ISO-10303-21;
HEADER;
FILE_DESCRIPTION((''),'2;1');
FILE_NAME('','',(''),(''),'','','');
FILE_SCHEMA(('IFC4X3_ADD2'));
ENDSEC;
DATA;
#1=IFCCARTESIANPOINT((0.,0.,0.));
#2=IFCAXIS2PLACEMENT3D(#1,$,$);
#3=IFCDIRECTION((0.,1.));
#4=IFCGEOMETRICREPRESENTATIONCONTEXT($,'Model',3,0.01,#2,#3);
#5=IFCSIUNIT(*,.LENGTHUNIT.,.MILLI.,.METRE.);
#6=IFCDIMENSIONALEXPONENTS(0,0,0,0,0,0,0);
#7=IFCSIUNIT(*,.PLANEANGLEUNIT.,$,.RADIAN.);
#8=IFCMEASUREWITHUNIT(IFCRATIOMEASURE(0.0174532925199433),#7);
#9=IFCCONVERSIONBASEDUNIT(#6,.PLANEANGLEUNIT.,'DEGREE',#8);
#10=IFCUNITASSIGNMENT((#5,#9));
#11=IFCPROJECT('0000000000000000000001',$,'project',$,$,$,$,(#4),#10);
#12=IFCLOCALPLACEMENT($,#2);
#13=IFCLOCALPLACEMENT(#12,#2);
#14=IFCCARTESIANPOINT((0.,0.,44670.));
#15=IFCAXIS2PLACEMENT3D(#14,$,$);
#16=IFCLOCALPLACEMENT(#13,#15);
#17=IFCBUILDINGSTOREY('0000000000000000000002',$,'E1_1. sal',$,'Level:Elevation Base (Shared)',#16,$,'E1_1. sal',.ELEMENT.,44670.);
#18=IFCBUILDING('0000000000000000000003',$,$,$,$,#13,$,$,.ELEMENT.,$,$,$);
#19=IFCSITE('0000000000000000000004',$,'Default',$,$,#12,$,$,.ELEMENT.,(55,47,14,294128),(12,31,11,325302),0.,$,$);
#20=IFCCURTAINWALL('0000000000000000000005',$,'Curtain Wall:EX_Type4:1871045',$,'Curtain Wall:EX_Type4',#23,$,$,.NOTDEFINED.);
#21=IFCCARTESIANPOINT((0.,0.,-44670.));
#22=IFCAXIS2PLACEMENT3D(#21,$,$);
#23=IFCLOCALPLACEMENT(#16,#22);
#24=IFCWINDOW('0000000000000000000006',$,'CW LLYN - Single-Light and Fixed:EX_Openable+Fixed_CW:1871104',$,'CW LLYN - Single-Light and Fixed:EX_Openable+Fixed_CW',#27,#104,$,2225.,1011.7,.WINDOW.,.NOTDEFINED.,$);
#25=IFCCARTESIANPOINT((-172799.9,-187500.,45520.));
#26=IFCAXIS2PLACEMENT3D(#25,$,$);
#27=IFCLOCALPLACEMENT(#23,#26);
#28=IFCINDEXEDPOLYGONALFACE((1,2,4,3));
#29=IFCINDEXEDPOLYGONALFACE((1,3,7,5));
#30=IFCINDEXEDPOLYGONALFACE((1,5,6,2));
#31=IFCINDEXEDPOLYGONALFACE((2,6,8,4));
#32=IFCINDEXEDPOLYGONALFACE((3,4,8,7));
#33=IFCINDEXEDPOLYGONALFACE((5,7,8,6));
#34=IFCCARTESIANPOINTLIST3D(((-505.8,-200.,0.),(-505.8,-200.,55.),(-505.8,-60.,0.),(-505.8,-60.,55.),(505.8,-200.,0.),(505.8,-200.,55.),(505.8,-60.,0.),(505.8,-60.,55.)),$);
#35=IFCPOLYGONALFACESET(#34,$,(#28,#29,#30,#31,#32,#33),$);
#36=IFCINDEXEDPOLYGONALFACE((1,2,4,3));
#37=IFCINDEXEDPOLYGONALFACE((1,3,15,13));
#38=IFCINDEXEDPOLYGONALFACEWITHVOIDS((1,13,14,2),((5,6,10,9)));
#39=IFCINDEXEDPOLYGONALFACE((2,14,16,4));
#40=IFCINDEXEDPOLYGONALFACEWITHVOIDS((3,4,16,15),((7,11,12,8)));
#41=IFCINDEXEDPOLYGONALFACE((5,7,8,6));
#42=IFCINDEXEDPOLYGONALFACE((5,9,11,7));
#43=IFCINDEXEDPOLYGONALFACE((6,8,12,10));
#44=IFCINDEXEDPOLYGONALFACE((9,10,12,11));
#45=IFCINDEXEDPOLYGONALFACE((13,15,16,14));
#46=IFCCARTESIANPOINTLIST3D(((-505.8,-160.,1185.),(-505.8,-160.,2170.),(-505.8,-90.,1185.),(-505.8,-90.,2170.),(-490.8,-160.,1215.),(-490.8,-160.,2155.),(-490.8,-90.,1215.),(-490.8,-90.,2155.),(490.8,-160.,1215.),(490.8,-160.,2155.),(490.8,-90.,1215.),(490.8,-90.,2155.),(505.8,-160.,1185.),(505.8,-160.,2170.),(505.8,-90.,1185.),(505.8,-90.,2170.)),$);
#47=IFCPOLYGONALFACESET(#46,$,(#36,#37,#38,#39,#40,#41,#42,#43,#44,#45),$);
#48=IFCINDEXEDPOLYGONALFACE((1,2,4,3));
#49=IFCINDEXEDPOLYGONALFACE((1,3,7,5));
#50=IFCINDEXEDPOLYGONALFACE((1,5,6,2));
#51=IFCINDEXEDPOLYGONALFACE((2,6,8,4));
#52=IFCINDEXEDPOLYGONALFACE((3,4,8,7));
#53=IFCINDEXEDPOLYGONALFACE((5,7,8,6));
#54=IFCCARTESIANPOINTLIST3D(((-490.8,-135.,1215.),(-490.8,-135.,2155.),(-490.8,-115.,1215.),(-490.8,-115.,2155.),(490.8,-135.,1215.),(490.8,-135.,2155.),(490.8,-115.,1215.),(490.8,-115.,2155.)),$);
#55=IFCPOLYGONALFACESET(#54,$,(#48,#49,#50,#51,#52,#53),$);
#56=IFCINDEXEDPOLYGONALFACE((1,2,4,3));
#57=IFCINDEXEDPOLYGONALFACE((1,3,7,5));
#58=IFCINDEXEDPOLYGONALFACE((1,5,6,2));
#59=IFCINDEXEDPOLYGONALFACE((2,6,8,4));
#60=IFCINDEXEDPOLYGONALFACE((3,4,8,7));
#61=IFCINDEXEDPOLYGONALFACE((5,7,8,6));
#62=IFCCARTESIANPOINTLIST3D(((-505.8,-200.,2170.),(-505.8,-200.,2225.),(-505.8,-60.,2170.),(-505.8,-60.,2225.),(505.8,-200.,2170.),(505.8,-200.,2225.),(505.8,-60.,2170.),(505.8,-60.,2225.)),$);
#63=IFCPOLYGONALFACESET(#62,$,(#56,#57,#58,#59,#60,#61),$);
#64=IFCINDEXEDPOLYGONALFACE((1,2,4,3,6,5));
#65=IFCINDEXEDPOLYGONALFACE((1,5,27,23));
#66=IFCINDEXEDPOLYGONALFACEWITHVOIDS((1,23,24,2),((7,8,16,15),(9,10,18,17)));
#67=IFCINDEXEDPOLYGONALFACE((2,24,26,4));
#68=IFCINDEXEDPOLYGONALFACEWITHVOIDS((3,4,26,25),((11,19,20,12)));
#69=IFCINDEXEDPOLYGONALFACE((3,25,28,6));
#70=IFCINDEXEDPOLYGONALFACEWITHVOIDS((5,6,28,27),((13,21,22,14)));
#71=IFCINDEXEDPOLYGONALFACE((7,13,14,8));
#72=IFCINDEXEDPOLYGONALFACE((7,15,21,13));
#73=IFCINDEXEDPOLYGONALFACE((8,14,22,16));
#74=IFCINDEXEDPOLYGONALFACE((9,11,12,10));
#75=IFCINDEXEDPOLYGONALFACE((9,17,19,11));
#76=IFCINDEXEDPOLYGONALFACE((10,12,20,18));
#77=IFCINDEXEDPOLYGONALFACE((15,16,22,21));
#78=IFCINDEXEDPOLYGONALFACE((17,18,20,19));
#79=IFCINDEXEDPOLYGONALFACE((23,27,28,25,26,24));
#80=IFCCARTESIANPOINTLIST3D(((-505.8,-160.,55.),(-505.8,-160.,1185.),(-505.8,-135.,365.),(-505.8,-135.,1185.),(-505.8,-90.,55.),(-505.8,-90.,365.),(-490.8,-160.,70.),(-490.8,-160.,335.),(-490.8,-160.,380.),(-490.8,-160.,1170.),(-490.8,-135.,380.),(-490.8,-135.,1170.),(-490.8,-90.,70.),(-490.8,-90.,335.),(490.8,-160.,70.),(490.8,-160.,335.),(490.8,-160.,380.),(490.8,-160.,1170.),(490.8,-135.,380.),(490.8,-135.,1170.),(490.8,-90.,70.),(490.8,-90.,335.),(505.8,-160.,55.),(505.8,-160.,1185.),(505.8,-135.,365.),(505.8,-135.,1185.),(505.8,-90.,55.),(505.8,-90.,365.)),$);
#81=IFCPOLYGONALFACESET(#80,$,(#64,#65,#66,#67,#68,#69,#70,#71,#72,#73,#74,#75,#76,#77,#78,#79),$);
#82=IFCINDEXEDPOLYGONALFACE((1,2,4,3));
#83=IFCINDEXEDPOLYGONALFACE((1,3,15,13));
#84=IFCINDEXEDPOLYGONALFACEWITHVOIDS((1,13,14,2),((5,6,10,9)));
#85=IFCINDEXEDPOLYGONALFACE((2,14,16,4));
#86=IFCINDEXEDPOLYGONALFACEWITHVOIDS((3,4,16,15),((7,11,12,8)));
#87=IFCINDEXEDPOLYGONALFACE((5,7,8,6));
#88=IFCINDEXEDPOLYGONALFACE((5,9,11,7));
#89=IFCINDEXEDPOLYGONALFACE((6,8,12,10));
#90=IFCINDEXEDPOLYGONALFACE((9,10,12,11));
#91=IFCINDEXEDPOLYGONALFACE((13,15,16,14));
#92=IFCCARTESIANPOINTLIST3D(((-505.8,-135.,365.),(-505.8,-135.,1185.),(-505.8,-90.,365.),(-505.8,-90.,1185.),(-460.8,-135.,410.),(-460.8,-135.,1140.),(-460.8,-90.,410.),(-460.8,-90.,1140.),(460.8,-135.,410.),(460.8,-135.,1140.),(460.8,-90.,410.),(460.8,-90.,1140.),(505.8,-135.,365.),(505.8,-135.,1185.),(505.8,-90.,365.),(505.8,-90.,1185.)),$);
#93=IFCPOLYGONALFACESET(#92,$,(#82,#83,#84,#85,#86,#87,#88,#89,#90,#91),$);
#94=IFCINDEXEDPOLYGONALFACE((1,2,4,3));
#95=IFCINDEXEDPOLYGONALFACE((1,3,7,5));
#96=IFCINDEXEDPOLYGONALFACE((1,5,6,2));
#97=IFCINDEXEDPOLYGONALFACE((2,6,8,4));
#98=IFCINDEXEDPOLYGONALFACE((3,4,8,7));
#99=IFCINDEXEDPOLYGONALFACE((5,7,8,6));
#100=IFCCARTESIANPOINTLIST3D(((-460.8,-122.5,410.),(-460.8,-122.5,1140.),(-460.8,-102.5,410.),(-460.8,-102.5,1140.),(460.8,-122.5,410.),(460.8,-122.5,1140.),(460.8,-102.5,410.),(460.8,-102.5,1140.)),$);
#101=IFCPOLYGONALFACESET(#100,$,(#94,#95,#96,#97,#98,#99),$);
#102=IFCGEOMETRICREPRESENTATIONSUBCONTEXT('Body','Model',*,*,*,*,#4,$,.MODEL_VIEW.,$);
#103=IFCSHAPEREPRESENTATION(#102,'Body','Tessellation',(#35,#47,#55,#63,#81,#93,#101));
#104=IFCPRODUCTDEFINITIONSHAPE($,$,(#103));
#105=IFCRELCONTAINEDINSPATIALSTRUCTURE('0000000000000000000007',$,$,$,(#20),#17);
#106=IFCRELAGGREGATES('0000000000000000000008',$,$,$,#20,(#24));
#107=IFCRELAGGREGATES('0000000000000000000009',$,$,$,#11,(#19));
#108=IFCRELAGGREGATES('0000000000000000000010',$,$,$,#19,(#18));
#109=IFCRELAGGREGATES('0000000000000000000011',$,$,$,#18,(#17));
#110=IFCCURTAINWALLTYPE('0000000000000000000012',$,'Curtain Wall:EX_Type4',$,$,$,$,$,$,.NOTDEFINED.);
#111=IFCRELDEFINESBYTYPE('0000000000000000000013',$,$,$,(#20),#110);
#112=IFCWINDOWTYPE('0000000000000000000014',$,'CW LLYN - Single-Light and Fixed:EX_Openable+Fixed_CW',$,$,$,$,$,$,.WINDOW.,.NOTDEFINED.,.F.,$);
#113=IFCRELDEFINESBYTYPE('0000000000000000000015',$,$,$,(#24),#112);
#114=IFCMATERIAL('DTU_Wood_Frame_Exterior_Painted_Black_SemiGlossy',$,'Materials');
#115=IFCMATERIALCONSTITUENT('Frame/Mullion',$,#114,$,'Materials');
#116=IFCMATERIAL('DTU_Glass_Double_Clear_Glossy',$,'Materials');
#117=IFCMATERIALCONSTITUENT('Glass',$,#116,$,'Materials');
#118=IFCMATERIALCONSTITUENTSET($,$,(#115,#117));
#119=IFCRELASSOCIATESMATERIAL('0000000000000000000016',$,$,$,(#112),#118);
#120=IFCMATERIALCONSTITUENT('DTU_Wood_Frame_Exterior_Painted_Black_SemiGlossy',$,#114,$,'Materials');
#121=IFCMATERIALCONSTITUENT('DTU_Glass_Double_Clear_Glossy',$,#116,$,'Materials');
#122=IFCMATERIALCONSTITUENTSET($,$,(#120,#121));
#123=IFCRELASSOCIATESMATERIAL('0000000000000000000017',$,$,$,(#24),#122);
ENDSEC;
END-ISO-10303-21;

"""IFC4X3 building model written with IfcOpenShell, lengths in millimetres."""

from ifc_helpers import new_model, entity, si_unit, converted_unit, direction, frame, frame_2d, origin, origin_2d_with_axis, place, context, subcontext, project, spatial, polyline, rectangle, outline, extrude, source, transform, mapped, material, constituent, constituent_set, type_object, type_shapes, element, aggregate, save


model = new_model("IFC4X3")

# Units and contexts
model_context = context("Model", 3, precision=0.01, world=origin(), true_north=direction((0.0, 1.0)))
body_context = subcontext(model_context, "Body", "Model", "MODEL_VIEW")
ifc_project = project(units=[si_unit("LENGTHUNIT", "METRE", prefix="MILLI"), converted_unit("PLANEANGLEUNIT", "DEGREE", entity("IfcRatioMeasure", 0.0174532925199433), si_unit("PLANEANGLEUNIT", "RADIAN"), dimensions=[0, 0, 0, 0, 0, 0, 0])], contexts=[model_context])

# Site, building, storey
site_placement = place(None, origin())
site = spatial("IfcSite", under=ifc_project, at=site_placement, Name="Default", CompositionType="ELEMENT", RefLatitude=(55, 47, 14, 294128), RefLongitude=(12, 31, 11, 325302), RefElevation=0.0)
building_placement = place(site_placement, origin())
building = spatial("IfcBuilding", under=site, at=building_placement, CompositionType="ELEMENT")
storey_placement = place(building_placement, frame((0.0, 0.0, 44670.0)))
storey = spatial("IfcBuildingStorey", under=building, at=storey_placement, Name="E1_1. sal", ObjectType="Level:Elevation Base (Shared)", LongName="E1_1. sal", CompositionType="ELEMENT", Elevation=44670.0)

# Curtain wall
curtain_wall_type_1 = type_object("IfcCurtainWallType", Name="Curtain Wall:EX_Type4", PredefinedType="NOTDEFINED")
curtain_wall_1_placement = place(storey_placement, frame((0.0, 0.0, -44670.0)))
curtain_wall_1 = element("IfcCurtainWall", 1, at=curtain_wall_1_placement, inside=storey, type_object=curtain_wall_type_1, Name="Curtain Wall:EX_Type4:1871045", ObjectType="Curtain Wall:EX_Type4", PredefinedType="NOTDEFINED")

# Shared definitions
ifc_material_1 = material(Name="DTU_Wood_Frame_Exterior_Painted_Black_SemiGlossy", Category="Materials")
ifc_material_2 = material(Name="DTU_Glass_Double_Clear_Glossy", Category="Materials")

# Window, openings
ifc_constituent_1 = constituent(ifc_material_1, Name="DTU_Wood_Frame_Exterior_Painted_Black_SemiGlossy", Category="Materials")
ifc_constituent_2 = constituent(ifc_material_2, Name="DTU_Glass_Double_Clear_Glossy", Category="Materials")
ifc_constituent_set_1 = constituent_set(constituents=[ifc_constituent_1, ifc_constituent_2])
ifc_constituent_3 = constituent(ifc_material_1, Name="Frame/Mullion", Category="Materials")
ifc_constituent_4 = constituent(ifc_material_2, Name="Glass", Category="Materials")
ifc_constituent_set_2 = constituent_set(constituents=[ifc_constituent_3, ifc_constituent_4])
window_type_1 = type_object("IfcWindowType", Name="CW LLYN - Single-Light and Fixed:EX_Openable+Fixed_CW", ParameterTakesPrecedence=False, PartitioningType="NOTDEFINED", PredefinedType="WINDOW", material=ifc_constituent_set_2)
shared_shape_1 = source(origin(), body_context, "Body", "SweptSolid", [
    extrude(rectangle(XDim=140.0, YDim=1011.7, at=origin_2d_with_axis()), frame((0.0, -130.0, 0.0), z_axis=(0.0, 0.0, 1.0), x_axis=(0.0, -1.0, 0.0)), (0.0, 0.0, 1.0), 55.0),
    extrude(outline(polyline([(-492.5, -505.8), (492.5, -505.8), (492.5, 505.8), (-492.5, 505.8), (-492.5, -505.8)]), holes=[polyline([(477.5, -490.8), (-462.5, -490.8), (-462.5, 490.8), (477.5, 490.8), (477.5, -490.8)])]), frame((0.0, -90.0, 1677.5), z_axis=(0.0, -1.0, 0.0), x_axis=(0.0, 0.0, 1.0)), (0.0, 0.0, 1.0), 70.0),
    extrude(rectangle(XDim=981.7, YDim=20.0, at=frame_2d((0.0, 0.0), x_axis=(1.0, 0.0))), frame((0.0, -125.0, 1215.0), z_axis=(0.0, 0.0, 1.0), x_axis=(-1.0, 0.0, 0.0)), (0.0, 0.0, 1.0), 940.0),
    extrude(rectangle(XDim=981.7, YDim=20.0, at=frame_2d((0.0, 0.0), x_axis=(1.0, 0.0))), frame((0.0, -125.0, 70.0), z_axis=(0.0, 0.0, 1.0), x_axis=(-1.0, 0.0, 0.0)), (0.0, 0.0, 1.0), 265.0),
    extrude(rectangle(XDim=140.0, YDim=1011.7, at=frame_2d((0.0, 0.0), x_axis=(1.0, 0.0))), frame((0.0, -130.0, 2170.0), z_axis=(0.0, 0.0, 1.0), x_axis=(0.0, -1.0, 0.0)), (0.0, 0.0, 1.0), 55.0),
    extrude(outline(polyline([(-38.3, -480.0), (31.7, -480.0), (31.7, 650.0), (6.7, 650.0), (6.7, -170.0), (-38.3, -170.0), (-38.3, -480.0)])), frame((505.8, -128.3, 535.0), z_axis=(-1.0, 0.0, 0.0), x_axis=(0.0, -1.0, 0.0)), (0.0, 0.0, 1.0), 1011.7),
    extrude(outline(polyline([(-410.0, -505.8), (410.0, -505.8), (410.0, 505.8), (-410.0, 505.8), (-410.0, -505.8)]), holes=[polyline([(-365.0, 460.8), (365.0, 460.8), (365.0, -460.8), (-365.0, -460.8), (-365.0, 460.8)])]), frame((0.0, -90.0, 775.0), z_axis=(0.0, -1.0, 0.0), x_axis=(0.0, 0.0, 1.0)), (0.0, 0.0, 1.0), 45.0),
    extrude(rectangle(XDim=921.7, YDim=20.0, at=frame_2d((0.0, 0.0), x_axis=(1.0, 0.0))), frame((0.0, -112.5, 410.0), z_axis=(0.0, 0.0, 1.0), x_axis=(-1.0, 0.0, 0.0)), (0.0, 0.0, 1.0), 730.0),
])
type_shapes(window_type_1, [shared_shape_1])
window_1_placement = place(curtain_wall_1_placement, frame((-172799.9, -187500.0, 45520.0)))
window_1 = element("IfcWindow", 2, at=window_1_placement, type_object=window_type_1, material=ifc_constituent_set_1, Name="CW LLYN - Single-Light and Fixed:EX_Openable+Fixed_CW:1871104", ObjectType="CW LLYN - Single-Light and Fixed:EX_Openable+Fixed_CW", OverallHeight=2225.0, OverallWidth=1011.7, PartitioningType="NOTDEFINED", PredefinedType="WINDOW", context=body_context, shape_type="MappedRepresentation", body=[
    mapped(shared_shape_1, transform((0.0, 0.0, 0.0), scale=1.0)),
])
opening_1_placement = place(curtain_wall_1_placement, frame((-172799.9, -187500.0, 90190.0), z_axis=(0.0, 0.0, 1.0), x_axis=(-1.0, 0.0, 0.0)))
opening_1 = element("IfcOpeningElement", 3, at=opening_1_placement, cuts=window_1, PredefinedType="OPENING", context=body_context, shape_type="SweptSolid", body=[
    extrude(rectangle(XDim=265.0, YDim=981.7, at=frame_2d((0.0, 0.0), x_axis=(1.0, 0.0))), frame((0.0, 160.0, -44467.5), z_axis=(0.0, -1.0, 0.0), x_axis=(0.0, 0.0, 1.0)), (0.0, 0.0, 1.0), 70.0),
])
opening_2_placement = place(curtain_wall_1_placement, frame((-172799.9, -187500.0, 90190.0), z_axis=(0.0, 0.0, 1.0), x_axis=(-1.0, 0.0, 0.0)))
opening_2 = element("IfcOpeningElement", 4, at=opening_2_placement, cuts=window_1, PredefinedType="OPENING", context=body_context, shape_type="SweptSolid", body=[
    extrude(rectangle(XDim=790.0, YDim=981.7, at=frame_2d((0.0, 0.0), x_axis=(1.0, 0.0))), frame((0.0, 135.0, -43895.0), z_axis=(0.0, 1.0, 0.0), x_axis=(0.0, 0.0, 1.0)), (0.0, 0.0, 1.0), 25.0),
])

aggregate(curtain_wall_1, [window_1, opening_1, opening_2])

save(model, "model.ifc")
